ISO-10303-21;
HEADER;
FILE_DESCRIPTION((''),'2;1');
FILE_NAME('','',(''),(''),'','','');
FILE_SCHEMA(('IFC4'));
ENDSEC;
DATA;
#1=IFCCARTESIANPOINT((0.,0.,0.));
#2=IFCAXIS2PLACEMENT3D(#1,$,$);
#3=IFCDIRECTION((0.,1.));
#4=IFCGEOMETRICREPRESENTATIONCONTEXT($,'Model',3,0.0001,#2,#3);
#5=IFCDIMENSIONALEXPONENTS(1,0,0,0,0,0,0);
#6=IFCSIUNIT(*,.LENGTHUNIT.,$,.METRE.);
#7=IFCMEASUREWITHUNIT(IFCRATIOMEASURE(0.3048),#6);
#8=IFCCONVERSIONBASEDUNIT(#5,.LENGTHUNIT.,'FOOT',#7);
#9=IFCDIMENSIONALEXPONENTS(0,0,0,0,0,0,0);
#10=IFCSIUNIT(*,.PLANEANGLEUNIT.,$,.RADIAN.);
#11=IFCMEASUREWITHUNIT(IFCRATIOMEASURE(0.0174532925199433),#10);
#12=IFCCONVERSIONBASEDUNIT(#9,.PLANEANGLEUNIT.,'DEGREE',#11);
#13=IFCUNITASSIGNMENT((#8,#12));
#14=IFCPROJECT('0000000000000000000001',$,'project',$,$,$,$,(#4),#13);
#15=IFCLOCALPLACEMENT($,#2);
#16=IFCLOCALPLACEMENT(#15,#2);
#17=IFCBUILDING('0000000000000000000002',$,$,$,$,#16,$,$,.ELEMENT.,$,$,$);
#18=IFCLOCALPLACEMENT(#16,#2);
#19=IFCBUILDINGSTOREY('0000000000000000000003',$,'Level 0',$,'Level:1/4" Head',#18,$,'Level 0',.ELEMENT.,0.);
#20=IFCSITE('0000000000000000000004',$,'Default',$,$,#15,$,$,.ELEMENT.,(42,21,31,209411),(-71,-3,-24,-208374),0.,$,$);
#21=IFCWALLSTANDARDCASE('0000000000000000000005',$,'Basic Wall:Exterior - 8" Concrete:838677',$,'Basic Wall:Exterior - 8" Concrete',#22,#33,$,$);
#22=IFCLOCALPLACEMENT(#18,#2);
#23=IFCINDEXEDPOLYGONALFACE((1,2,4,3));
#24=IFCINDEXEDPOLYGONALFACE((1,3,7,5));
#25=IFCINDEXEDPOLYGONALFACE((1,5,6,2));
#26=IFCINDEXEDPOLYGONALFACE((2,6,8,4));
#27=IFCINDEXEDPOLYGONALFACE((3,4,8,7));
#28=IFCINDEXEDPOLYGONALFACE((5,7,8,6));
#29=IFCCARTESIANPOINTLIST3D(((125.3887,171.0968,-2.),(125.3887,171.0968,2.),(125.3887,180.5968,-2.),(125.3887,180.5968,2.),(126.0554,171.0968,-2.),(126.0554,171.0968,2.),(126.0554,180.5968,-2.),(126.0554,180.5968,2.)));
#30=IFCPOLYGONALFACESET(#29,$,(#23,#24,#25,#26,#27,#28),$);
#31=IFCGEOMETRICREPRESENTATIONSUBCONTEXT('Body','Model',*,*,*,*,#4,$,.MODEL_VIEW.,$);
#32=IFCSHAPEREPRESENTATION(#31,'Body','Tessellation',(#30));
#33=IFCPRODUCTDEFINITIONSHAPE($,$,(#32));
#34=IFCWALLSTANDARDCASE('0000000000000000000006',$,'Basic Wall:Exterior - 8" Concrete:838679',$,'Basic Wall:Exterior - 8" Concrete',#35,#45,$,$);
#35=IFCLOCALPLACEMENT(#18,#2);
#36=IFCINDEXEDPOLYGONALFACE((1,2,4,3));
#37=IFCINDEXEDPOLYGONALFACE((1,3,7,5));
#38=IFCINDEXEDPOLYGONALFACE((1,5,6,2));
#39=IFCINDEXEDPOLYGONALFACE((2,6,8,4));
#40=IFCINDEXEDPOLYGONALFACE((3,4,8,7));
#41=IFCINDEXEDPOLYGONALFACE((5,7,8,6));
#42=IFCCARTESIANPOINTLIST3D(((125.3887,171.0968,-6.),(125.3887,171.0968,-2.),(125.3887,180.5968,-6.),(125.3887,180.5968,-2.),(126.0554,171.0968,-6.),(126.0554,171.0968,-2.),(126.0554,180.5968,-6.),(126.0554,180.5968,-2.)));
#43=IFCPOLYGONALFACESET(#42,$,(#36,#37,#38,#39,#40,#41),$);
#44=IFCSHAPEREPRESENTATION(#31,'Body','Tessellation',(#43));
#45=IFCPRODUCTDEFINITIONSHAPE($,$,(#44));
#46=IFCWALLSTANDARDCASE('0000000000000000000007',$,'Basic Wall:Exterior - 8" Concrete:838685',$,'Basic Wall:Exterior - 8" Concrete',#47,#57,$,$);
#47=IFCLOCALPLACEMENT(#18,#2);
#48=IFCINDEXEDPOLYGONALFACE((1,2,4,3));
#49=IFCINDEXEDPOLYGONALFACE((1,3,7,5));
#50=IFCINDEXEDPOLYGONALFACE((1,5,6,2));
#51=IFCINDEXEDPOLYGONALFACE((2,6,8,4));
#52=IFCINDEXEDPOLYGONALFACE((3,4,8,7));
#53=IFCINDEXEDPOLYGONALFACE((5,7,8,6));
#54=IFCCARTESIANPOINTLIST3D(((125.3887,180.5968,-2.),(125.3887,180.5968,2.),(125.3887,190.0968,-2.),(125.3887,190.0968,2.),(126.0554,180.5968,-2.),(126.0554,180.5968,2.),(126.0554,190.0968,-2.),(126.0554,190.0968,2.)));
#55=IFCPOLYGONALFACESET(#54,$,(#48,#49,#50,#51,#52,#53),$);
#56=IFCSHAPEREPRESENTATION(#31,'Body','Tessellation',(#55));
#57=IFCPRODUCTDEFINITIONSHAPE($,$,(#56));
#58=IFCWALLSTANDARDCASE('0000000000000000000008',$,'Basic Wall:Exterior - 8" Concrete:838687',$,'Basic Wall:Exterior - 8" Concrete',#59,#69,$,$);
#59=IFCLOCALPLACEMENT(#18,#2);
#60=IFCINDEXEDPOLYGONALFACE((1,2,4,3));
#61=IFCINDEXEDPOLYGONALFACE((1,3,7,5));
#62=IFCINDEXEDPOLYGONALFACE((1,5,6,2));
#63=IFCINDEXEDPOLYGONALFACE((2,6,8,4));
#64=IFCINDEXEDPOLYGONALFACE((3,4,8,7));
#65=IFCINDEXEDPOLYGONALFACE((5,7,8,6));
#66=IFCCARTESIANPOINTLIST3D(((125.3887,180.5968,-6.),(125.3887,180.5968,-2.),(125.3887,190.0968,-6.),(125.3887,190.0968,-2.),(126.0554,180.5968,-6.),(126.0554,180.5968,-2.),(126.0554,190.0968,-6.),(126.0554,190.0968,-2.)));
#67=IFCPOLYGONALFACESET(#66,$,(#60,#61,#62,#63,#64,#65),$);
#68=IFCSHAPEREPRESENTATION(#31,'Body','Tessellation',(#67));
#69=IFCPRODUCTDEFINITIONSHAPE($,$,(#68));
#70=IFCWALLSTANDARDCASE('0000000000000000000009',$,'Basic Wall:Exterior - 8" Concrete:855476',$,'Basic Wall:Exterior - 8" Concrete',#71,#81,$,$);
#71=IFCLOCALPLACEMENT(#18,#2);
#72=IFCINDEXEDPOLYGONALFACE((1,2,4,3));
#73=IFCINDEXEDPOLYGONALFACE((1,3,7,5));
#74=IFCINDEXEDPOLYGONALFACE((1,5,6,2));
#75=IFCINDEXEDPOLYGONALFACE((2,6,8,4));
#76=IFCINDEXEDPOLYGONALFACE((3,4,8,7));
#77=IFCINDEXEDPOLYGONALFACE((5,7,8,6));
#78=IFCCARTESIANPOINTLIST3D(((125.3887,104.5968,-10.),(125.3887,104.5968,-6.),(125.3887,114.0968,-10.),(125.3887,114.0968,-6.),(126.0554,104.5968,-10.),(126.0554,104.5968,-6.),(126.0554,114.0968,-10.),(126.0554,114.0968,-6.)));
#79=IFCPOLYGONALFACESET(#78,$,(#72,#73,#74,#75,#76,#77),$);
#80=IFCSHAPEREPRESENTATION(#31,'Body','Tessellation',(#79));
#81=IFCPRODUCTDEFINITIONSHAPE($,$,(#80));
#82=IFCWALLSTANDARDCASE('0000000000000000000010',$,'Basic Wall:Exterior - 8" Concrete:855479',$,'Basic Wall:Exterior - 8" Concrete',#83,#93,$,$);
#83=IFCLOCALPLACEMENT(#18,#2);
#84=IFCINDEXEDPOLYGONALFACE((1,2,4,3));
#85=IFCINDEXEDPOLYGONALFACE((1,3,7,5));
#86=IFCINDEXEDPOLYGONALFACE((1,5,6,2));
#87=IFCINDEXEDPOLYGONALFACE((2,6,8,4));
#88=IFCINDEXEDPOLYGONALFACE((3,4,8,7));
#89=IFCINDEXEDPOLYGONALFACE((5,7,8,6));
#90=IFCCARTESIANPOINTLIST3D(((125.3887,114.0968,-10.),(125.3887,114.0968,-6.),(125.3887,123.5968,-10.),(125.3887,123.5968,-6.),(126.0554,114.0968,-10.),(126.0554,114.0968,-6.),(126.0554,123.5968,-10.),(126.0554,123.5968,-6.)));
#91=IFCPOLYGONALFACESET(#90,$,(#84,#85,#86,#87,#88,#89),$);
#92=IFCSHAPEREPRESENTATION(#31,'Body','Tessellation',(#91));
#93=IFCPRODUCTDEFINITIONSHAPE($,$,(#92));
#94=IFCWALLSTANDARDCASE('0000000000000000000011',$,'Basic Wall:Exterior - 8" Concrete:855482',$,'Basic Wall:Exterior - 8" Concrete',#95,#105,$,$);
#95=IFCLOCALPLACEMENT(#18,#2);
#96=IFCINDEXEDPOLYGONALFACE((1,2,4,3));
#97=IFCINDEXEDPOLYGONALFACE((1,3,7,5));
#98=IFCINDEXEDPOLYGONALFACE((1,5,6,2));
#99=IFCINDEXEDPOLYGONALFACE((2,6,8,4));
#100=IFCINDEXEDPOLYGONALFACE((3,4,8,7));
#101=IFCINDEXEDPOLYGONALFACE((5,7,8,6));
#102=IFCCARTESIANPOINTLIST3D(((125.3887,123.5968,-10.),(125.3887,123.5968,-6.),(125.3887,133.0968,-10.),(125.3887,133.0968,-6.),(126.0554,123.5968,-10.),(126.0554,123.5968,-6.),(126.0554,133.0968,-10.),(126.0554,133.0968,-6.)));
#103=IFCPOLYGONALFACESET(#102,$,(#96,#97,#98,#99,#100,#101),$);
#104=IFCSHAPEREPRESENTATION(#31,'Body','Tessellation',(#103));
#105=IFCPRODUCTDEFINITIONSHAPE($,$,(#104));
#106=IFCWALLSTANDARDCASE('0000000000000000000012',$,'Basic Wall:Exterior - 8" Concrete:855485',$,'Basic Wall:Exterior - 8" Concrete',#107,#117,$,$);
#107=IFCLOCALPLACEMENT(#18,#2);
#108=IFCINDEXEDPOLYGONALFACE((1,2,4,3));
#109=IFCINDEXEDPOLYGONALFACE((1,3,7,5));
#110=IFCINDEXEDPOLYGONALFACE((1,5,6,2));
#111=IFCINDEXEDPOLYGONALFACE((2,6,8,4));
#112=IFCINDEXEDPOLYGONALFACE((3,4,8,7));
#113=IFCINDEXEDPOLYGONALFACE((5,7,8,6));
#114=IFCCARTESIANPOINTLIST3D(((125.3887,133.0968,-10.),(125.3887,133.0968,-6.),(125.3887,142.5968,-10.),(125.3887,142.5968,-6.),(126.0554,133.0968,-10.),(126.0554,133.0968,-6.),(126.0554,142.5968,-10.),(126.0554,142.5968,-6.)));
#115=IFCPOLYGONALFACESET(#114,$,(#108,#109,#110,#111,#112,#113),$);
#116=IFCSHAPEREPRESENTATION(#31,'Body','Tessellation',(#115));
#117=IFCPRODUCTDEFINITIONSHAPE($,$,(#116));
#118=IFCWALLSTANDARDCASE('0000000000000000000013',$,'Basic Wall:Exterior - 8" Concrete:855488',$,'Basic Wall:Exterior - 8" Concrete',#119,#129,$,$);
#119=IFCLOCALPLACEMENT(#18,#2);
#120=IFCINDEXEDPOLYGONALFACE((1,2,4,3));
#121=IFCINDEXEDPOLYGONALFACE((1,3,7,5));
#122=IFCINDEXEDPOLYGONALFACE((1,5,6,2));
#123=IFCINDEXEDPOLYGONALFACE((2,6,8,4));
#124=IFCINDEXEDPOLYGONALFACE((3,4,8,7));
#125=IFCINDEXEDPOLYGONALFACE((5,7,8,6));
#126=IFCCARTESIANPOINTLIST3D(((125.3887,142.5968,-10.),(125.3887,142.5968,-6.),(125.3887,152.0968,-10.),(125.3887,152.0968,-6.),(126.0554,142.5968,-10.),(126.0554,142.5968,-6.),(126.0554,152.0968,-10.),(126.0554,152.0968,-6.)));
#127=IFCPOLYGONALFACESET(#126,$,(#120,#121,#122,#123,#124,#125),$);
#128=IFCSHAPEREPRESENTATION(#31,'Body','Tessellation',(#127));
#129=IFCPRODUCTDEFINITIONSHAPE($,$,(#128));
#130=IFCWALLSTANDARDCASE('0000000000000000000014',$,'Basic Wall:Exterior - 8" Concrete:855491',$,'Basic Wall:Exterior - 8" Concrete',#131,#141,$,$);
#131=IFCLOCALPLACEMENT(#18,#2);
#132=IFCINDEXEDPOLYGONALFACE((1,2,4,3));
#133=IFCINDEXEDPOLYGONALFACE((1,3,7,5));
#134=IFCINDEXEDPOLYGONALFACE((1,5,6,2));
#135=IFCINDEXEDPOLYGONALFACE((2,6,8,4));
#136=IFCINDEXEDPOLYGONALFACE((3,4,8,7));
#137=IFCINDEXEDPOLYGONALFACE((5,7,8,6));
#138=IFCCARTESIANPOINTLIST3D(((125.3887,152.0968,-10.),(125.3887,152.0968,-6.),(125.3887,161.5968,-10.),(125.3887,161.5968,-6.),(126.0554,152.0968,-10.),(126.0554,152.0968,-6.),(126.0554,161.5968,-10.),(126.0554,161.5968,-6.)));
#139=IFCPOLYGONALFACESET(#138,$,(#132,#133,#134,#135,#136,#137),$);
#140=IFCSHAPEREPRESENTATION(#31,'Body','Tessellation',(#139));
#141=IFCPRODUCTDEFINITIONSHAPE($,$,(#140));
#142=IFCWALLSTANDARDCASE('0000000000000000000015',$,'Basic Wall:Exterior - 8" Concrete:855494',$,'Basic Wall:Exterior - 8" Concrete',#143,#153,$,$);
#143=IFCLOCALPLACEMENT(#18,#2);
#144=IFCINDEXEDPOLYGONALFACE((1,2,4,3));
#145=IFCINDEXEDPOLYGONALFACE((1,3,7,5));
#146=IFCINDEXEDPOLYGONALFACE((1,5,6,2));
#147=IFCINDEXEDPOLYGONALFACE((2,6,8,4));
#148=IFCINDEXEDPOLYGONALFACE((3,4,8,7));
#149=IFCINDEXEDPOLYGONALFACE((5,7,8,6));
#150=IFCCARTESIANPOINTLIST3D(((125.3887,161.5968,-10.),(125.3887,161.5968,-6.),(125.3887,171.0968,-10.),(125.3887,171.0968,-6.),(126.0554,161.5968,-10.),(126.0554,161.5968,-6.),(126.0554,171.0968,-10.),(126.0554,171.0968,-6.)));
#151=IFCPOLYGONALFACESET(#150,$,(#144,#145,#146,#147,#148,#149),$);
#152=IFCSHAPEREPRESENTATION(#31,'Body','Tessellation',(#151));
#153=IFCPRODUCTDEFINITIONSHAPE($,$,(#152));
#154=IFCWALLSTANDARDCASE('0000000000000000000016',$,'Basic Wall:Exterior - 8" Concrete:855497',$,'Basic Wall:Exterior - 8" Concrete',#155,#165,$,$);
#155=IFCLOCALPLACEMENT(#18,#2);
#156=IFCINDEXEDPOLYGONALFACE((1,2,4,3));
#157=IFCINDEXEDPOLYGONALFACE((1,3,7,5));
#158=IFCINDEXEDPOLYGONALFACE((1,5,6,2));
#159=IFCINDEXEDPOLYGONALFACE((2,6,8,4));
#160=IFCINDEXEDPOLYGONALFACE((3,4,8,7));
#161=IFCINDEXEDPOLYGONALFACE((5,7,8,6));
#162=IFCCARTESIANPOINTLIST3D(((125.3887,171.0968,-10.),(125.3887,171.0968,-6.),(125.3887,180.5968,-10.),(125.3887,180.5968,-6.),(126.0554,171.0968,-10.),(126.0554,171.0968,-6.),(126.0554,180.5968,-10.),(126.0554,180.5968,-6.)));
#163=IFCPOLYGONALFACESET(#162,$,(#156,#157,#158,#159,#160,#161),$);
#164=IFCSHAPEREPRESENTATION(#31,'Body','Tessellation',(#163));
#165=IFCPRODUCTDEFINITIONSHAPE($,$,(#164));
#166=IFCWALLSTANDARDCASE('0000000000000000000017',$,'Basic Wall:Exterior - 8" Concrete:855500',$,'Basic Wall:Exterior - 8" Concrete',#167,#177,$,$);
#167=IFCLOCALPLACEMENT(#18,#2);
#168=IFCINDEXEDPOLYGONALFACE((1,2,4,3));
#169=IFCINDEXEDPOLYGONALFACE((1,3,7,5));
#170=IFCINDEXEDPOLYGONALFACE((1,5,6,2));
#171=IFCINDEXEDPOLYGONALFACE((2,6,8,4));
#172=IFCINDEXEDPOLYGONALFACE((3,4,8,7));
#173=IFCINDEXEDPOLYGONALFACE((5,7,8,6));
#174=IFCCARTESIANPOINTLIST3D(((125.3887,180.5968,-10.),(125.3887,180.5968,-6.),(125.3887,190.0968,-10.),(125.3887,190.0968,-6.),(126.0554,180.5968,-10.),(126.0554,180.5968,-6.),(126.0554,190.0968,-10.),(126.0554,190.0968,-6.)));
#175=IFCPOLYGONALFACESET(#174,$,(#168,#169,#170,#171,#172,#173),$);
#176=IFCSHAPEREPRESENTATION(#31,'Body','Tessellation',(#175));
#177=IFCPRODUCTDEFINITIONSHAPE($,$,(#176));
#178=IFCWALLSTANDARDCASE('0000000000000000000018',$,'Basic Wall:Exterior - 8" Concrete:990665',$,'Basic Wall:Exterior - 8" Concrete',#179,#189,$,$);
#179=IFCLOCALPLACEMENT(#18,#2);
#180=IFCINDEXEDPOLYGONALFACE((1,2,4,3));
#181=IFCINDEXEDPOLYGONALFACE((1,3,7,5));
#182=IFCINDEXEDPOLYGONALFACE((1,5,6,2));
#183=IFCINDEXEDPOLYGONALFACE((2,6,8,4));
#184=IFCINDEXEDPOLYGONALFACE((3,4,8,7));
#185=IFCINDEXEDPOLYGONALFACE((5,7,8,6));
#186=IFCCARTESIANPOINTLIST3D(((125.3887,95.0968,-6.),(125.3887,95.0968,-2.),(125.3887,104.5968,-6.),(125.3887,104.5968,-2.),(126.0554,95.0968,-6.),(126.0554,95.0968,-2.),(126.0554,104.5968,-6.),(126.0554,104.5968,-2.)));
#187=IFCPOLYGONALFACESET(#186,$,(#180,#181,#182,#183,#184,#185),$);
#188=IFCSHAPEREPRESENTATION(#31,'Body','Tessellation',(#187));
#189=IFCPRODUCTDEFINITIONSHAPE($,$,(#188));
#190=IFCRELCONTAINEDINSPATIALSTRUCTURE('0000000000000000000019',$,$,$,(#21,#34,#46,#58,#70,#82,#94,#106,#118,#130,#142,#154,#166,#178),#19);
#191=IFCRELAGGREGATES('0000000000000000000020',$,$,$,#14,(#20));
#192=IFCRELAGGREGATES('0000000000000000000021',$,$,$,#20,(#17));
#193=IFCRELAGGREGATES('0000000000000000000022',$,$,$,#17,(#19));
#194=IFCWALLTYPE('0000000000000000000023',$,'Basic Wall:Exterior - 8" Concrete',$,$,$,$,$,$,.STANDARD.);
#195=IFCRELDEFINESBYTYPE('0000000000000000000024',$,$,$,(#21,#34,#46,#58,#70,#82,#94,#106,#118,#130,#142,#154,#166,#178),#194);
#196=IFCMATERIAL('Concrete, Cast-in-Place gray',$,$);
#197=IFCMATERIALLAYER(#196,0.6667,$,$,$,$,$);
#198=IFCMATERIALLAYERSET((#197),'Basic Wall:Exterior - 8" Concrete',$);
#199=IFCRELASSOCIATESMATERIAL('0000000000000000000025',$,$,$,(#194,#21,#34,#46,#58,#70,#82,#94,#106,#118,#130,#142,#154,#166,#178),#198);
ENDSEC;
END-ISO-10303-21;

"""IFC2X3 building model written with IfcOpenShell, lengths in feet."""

from ifc_helpers import new_model, entity, si_unit, converted_unit, direction, frame, frame_2d, origin, place, context, subcontext, project, spatial, rectangle, extrude, material, layer, layer_set, layer_usage, type_object, element, save


model = new_model("IFC2X3")

# Units and contexts
model_context = context("Model", 3, precision=0.0001, world=origin(), true_north=direction((0.0, 1.0)))
body_context = subcontext(model_context, "Body", "Model", "MODEL_VIEW")
ifc_project = project(units=[converted_unit("LENGTHUNIT", "FOOT", entity("IfcRatioMeasure", 0.3048), si_unit("LENGTHUNIT", "METRE"), dimensions=[1, 0, 0, 0, 0, 0, 0]), converted_unit("PLANEANGLEUNIT", "DEGREE", entity("IfcRatioMeasure", 0.0174532925199433), si_unit("PLANEANGLEUNIT", "RADIAN"), dimensions=[0, 0, 0, 0, 0, 0, 0])], contexts=[model_context])

# Site, building, storey
site_placement = place(None, origin())
site = spatial("IfcSite", under=ifc_project, at=site_placement, Name="Default", CompositionType="ELEMENT", RefLatitude=(42, 21, 31, 209411), RefLongitude=(-71, -3, -24, -208374), RefElevation=0.0)
building_placement = place(site_placement, origin())
building = spatial("IfcBuilding", under=site, at=building_placement, CompositionType="ELEMENT")
storey_placement = place(building_placement, origin())
storey = spatial("IfcBuildingStorey", under=building, at=storey_placement, Name="Level 0", ObjectType="Level:1/4\" Head", LongName="Level 0", CompositionType="ELEMENT", Elevation=0.0)

# Walls
ifc_material_1 = material(Name="Concrete, Cast-in-Place gray")
ifc_layer = layer(ifc_material_1, 0.6667)
ifc_layer_set = layer_set([ifc_layer], Name="Basic Wall:Exterior - 8\" Concrete")
wall_type = type_object("IfcWallType", Name="Basic Wall:Exterior - 8\" Concrete", PredefinedType="STANDARD", material=ifc_layer_set)
ifc_layer_usage_1 = layer_usage(ifc_layer_set, "AXIS2", "NEGATIVE", 0.3333)
wall_1_placement = place(storey_placement, frame((125.722, 171.0968, -2.0), z_axis=(0.0, 0.0, 1.0), x_axis=(0.0, 1.0, 0.0)))
element("IfcWallStandardCase", 1, at=wall_1_placement, inside=storey, type_object=wall_type, material=ifc_layer_usage_1, Name="Basic Wall:Exterior - 8\" Concrete:838677", ObjectType="Basic Wall:Exterior - 8\" Concrete", context=body_context, shape_type="SweptSolid", body=[
    extrude(rectangle(XDim=9.5, YDim=0.6667, at=frame_2d((4.75, 0.0), x_axis=(-1.0, 0.0))), origin(), (0.0, 0.0, 1.0), 4.0),
])
ifc_layer_usage_2 = layer_usage(ifc_layer_set, "AXIS2", "NEGATIVE", 0.3333)
wall_2_placement = place(storey_placement, frame((125.722, 171.0968, -6.0), z_axis=(0.0, 0.0, 1.0), x_axis=(0.0, 1.0, 0.0)))
element("IfcWallStandardCase", 2, at=wall_2_placement, inside=storey, type_object=wall_type, material=ifc_layer_usage_2, Name="Basic Wall:Exterior - 8\" Concrete:838679", ObjectType="Basic Wall:Exterior - 8\" Concrete", context=body_context, shape_type="SweptSolid", body=[
    extrude(rectangle(XDim=9.5, YDim=0.6667, at=frame_2d((4.75, 0.0), x_axis=(-1.0, 0.0))), origin(), (0.0, 0.0, 1.0), 4.0),
])
ifc_layer_usage_3 = layer_usage(ifc_layer_set, "AXIS2", "NEGATIVE", 0.3333)
wall_3_placement = place(storey_placement, frame((125.722, 180.5968, -2.0), z_axis=(0.0, 0.0, 1.0), x_axis=(0.0, 1.0, 0.0)))
element("IfcWallStandardCase", 3, at=wall_3_placement, inside=storey, type_object=wall_type, material=ifc_layer_usage_3, Name="Basic Wall:Exterior - 8\" Concrete:838685", ObjectType="Basic Wall:Exterior - 8\" Concrete", context=body_context, shape_type="SweptSolid", body=[
    extrude(rectangle(XDim=9.5, YDim=0.6667, at=frame_2d((4.75, 0.0), x_axis=(-1.0, 0.0))), origin(), (0.0, 0.0, 1.0), 4.0),
])
ifc_layer_usage_4 = layer_usage(ifc_layer_set, "AXIS2", "NEGATIVE", 0.3333)
wall_4_placement = place(storey_placement, frame((125.722, 180.5968, -6.0), z_axis=(0.0, 0.0, 1.0), x_axis=(0.0, 1.0, 0.0)))
element("IfcWallStandardCase", 4, at=wall_4_placement, inside=storey, type_object=wall_type, material=ifc_layer_usage_4, Name="Basic Wall:Exterior - 8\" Concrete:838687", ObjectType="Basic Wall:Exterior - 8\" Concrete", context=body_context, shape_type="SweptSolid", body=[
    extrude(rectangle(XDim=9.5, YDim=0.6667, at=frame_2d((4.75, 0.0), x_axis=(-1.0, 0.0))), origin(), (0.0, 0.0, 1.0), 4.0),
])
ifc_layer_usage_5 = layer_usage(ifc_layer_set, "AXIS2", "NEGATIVE", 0.3333)
wall_5_placement = place(storey_placement, frame((125.722, 104.5968, -10.0), z_axis=(0.0, 0.0, 1.0), x_axis=(0.0, 1.0, 0.0)))
element("IfcWallStandardCase", 5, at=wall_5_placement, inside=storey, type_object=wall_type, material=ifc_layer_usage_5, Name="Basic Wall:Exterior - 8\" Concrete:855476", ObjectType="Basic Wall:Exterior - 8\" Concrete", context=body_context, shape_type="SweptSolid", body=[
    extrude(rectangle(XDim=9.5, YDim=0.6667, at=frame_2d((4.75, 0.0), x_axis=(-1.0, 0.0))), origin(), (0.0, 0.0, 1.0), 4.0),
])
ifc_layer_usage_6 = layer_usage(ifc_layer_set, "AXIS2", "NEGATIVE", 0.3333)
wall_6_placement = place(storey_placement, frame((125.722, 114.0968, -10.0), z_axis=(0.0, 0.0, 1.0), x_axis=(0.0, 1.0, 0.0)))
element("IfcWallStandardCase", 6, at=wall_6_placement, inside=storey, type_object=wall_type, material=ifc_layer_usage_6, Name="Basic Wall:Exterior - 8\" Concrete:855479", ObjectType="Basic Wall:Exterior - 8\" Concrete", context=body_context, shape_type="SweptSolid", body=[
    extrude(rectangle(XDim=9.5, YDim=0.6667, at=frame_2d((4.75, 0.0), x_axis=(-1.0, 0.0))), origin(), (0.0, 0.0, 1.0), 4.0),
])
ifc_layer_usage_7 = layer_usage(ifc_layer_set, "AXIS2", "NEGATIVE", 0.3333)
wall_7_placement = place(storey_placement, frame((125.722, 123.5968, -10.0), z_axis=(0.0, 0.0, 1.0), x_axis=(0.0, 1.0, 0.0)))
element("IfcWallStandardCase", 7, at=wall_7_placement, inside=storey, type_object=wall_type, material=ifc_layer_usage_7, Name="Basic Wall:Exterior - 8\" Concrete:855482", ObjectType="Basic Wall:Exterior - 8\" Concrete", context=body_context, shape_type="SweptSolid", body=[
    extrude(rectangle(XDim=9.5, YDim=0.6667, at=frame_2d((4.75, 0.0), x_axis=(-1.0, 0.0))), origin(), (0.0, 0.0, 1.0), 4.0),
])
ifc_layer_usage_8 = layer_usage(ifc_layer_set, "AXIS2", "NEGATIVE", 0.3333)
wall_8_placement = place(storey_placement, frame((125.722, 133.0968, -10.0), z_axis=(0.0, 0.0, 1.0), x_axis=(0.0, 1.0, 0.0)))
element("IfcWallStandardCase", 8, at=wall_8_placement, inside=storey, type_object=wall_type, material=ifc_layer_usage_8, Name="Basic Wall:Exterior - 8\" Concrete:855485", ObjectType="Basic Wall:Exterior - 8\" Concrete", context=body_context, shape_type="SweptSolid", body=[
    extrude(rectangle(XDim=9.5, YDim=0.6667, at=frame_2d((4.75, 0.0), x_axis=(-1.0, 0.0))), origin(), (0.0, 0.0, 1.0), 4.0),
])
ifc_layer_usage_9 = layer_usage(ifc_layer_set, "AXIS2", "NEGATIVE", 0.3333)
wall_9_placement = place(storey_placement, frame((125.722, 142.5968, -10.0), z_axis=(0.0, 0.0, 1.0), x_axis=(0.0, 1.0, 0.0)))
element("IfcWallStandardCase", 9, at=wall_9_placement, inside=storey, type_object=wall_type, material=ifc_layer_usage_9, Name="Basic Wall:Exterior - 8\" Concrete:855488", ObjectType="Basic Wall:Exterior - 8\" Concrete", context=body_context, shape_type="SweptSolid", body=[
    extrude(rectangle(XDim=9.5, YDim=0.6667, at=frame_2d((4.75, 0.0), x_axis=(-1.0, 0.0))), origin(), (0.0, 0.0, 1.0), 4.0),
])
ifc_layer_usage_10 = layer_usage(ifc_layer_set, "AXIS2", "NEGATIVE", 0.3333)
wall_10_placement = place(storey_placement, frame((125.722, 152.0968, -10.0), z_axis=(0.0, 0.0, 1.0), x_axis=(0.0, 1.0, 0.0)))
element("IfcWallStandardCase", 10, at=wall_10_placement, inside=storey, type_object=wall_type, material=ifc_layer_usage_10, Name="Basic Wall:Exterior - 8\" Concrete:855491", ObjectType="Basic Wall:Exterior - 8\" Concrete", context=body_context, shape_type="SweptSolid", body=[
    extrude(rectangle(XDim=9.5, YDim=0.6667, at=frame_2d((4.75, 0.0), x_axis=(-1.0, 0.0))), origin(), (0.0, 0.0, 1.0), 4.0),
])
ifc_layer_usage_11 = layer_usage(ifc_layer_set, "AXIS2", "NEGATIVE", 0.3333)
wall_11_placement = place(storey_placement, frame((125.722, 161.5968, -10.0), z_axis=(0.0, 0.0, 1.0), x_axis=(0.0, 1.0, 0.0)))
element("IfcWallStandardCase", 11, at=wall_11_placement, inside=storey, type_object=wall_type, material=ifc_layer_usage_11, Name="Basic Wall:Exterior - 8\" Concrete:855494", ObjectType="Basic Wall:Exterior - 8\" Concrete", context=body_context, shape_type="SweptSolid", body=[
    extrude(rectangle(XDim=9.5, YDim=0.6667, at=frame_2d((4.75, 0.0), x_axis=(-1.0, 0.0))), origin(), (0.0, 0.0, 1.0), 4.0),
])
ifc_layer_usage_12 = layer_usage(ifc_layer_set, "AXIS2", "NEGATIVE", 0.3333)
wall_12_placement = place(storey_placement, frame((125.722, 171.0968, -10.0), z_axis=(0.0, 0.0, 1.0), x_axis=(0.0, 1.0, 0.0)))
element("IfcWallStandardCase", 12, at=wall_12_placement, inside=storey, type_object=wall_type, material=ifc_layer_usage_12, Name="Basic Wall:Exterior - 8\" Concrete:855497", ObjectType="Basic Wall:Exterior - 8\" Concrete", context=body_context, shape_type="SweptSolid", body=[
    extrude(rectangle(XDim=9.5, YDim=0.6667, at=frame_2d((4.75, 0.0), x_axis=(-1.0, 0.0))), origin(), (0.0, 0.0, 1.0), 4.0),
])
ifc_layer_usage_13 = layer_usage(ifc_layer_set, "AXIS2", "NEGATIVE", 0.3333)
wall_13_placement = place(storey_placement, frame((125.722, 180.5968, -10.0), z_axis=(0.0, 0.0, 1.0), x_axis=(0.0, 1.0, 0.0)))
element("IfcWallStandardCase", 13, at=wall_13_placement, inside=storey, type_object=wall_type, material=ifc_layer_usage_13, Name="Basic Wall:Exterior - 8\" Concrete:855500", ObjectType="Basic Wall:Exterior - 8\" Concrete", context=body_context, shape_type="SweptSolid", body=[
    extrude(rectangle(XDim=9.5, YDim=0.6667, at=frame_2d((4.75, 0.0), x_axis=(-1.0, 0.0))), origin(), (0.0, 0.0, 1.0), 4.0),
])
ifc_layer_usage_14 = layer_usage(ifc_layer_set, "AXIS2", "NEGATIVE", 0.3333)
wall_14_placement = place(storey_placement, frame((125.722, 95.0968, -6.0), z_axis=(0.0, 0.0, 1.0), x_axis=(0.0, 1.0, 0.0)))
element("IfcWallStandardCase", 14, at=wall_14_placement, inside=storey, type_object=wall_type, material=ifc_layer_usage_14, Name="Basic Wall:Exterior - 8\" Concrete:990665", ObjectType="Basic Wall:Exterior - 8\" Concrete", context=body_context, shape_type="SweptSolid", body=[
    extrude(rectangle(XDim=9.5, YDim=0.6667, at=frame_2d((4.75, 0.0), x_axis=(-1.0, 0.0))), origin(), (0.0, 0.0, 1.0), 4.0),
])

save(model, "model.ifc")
